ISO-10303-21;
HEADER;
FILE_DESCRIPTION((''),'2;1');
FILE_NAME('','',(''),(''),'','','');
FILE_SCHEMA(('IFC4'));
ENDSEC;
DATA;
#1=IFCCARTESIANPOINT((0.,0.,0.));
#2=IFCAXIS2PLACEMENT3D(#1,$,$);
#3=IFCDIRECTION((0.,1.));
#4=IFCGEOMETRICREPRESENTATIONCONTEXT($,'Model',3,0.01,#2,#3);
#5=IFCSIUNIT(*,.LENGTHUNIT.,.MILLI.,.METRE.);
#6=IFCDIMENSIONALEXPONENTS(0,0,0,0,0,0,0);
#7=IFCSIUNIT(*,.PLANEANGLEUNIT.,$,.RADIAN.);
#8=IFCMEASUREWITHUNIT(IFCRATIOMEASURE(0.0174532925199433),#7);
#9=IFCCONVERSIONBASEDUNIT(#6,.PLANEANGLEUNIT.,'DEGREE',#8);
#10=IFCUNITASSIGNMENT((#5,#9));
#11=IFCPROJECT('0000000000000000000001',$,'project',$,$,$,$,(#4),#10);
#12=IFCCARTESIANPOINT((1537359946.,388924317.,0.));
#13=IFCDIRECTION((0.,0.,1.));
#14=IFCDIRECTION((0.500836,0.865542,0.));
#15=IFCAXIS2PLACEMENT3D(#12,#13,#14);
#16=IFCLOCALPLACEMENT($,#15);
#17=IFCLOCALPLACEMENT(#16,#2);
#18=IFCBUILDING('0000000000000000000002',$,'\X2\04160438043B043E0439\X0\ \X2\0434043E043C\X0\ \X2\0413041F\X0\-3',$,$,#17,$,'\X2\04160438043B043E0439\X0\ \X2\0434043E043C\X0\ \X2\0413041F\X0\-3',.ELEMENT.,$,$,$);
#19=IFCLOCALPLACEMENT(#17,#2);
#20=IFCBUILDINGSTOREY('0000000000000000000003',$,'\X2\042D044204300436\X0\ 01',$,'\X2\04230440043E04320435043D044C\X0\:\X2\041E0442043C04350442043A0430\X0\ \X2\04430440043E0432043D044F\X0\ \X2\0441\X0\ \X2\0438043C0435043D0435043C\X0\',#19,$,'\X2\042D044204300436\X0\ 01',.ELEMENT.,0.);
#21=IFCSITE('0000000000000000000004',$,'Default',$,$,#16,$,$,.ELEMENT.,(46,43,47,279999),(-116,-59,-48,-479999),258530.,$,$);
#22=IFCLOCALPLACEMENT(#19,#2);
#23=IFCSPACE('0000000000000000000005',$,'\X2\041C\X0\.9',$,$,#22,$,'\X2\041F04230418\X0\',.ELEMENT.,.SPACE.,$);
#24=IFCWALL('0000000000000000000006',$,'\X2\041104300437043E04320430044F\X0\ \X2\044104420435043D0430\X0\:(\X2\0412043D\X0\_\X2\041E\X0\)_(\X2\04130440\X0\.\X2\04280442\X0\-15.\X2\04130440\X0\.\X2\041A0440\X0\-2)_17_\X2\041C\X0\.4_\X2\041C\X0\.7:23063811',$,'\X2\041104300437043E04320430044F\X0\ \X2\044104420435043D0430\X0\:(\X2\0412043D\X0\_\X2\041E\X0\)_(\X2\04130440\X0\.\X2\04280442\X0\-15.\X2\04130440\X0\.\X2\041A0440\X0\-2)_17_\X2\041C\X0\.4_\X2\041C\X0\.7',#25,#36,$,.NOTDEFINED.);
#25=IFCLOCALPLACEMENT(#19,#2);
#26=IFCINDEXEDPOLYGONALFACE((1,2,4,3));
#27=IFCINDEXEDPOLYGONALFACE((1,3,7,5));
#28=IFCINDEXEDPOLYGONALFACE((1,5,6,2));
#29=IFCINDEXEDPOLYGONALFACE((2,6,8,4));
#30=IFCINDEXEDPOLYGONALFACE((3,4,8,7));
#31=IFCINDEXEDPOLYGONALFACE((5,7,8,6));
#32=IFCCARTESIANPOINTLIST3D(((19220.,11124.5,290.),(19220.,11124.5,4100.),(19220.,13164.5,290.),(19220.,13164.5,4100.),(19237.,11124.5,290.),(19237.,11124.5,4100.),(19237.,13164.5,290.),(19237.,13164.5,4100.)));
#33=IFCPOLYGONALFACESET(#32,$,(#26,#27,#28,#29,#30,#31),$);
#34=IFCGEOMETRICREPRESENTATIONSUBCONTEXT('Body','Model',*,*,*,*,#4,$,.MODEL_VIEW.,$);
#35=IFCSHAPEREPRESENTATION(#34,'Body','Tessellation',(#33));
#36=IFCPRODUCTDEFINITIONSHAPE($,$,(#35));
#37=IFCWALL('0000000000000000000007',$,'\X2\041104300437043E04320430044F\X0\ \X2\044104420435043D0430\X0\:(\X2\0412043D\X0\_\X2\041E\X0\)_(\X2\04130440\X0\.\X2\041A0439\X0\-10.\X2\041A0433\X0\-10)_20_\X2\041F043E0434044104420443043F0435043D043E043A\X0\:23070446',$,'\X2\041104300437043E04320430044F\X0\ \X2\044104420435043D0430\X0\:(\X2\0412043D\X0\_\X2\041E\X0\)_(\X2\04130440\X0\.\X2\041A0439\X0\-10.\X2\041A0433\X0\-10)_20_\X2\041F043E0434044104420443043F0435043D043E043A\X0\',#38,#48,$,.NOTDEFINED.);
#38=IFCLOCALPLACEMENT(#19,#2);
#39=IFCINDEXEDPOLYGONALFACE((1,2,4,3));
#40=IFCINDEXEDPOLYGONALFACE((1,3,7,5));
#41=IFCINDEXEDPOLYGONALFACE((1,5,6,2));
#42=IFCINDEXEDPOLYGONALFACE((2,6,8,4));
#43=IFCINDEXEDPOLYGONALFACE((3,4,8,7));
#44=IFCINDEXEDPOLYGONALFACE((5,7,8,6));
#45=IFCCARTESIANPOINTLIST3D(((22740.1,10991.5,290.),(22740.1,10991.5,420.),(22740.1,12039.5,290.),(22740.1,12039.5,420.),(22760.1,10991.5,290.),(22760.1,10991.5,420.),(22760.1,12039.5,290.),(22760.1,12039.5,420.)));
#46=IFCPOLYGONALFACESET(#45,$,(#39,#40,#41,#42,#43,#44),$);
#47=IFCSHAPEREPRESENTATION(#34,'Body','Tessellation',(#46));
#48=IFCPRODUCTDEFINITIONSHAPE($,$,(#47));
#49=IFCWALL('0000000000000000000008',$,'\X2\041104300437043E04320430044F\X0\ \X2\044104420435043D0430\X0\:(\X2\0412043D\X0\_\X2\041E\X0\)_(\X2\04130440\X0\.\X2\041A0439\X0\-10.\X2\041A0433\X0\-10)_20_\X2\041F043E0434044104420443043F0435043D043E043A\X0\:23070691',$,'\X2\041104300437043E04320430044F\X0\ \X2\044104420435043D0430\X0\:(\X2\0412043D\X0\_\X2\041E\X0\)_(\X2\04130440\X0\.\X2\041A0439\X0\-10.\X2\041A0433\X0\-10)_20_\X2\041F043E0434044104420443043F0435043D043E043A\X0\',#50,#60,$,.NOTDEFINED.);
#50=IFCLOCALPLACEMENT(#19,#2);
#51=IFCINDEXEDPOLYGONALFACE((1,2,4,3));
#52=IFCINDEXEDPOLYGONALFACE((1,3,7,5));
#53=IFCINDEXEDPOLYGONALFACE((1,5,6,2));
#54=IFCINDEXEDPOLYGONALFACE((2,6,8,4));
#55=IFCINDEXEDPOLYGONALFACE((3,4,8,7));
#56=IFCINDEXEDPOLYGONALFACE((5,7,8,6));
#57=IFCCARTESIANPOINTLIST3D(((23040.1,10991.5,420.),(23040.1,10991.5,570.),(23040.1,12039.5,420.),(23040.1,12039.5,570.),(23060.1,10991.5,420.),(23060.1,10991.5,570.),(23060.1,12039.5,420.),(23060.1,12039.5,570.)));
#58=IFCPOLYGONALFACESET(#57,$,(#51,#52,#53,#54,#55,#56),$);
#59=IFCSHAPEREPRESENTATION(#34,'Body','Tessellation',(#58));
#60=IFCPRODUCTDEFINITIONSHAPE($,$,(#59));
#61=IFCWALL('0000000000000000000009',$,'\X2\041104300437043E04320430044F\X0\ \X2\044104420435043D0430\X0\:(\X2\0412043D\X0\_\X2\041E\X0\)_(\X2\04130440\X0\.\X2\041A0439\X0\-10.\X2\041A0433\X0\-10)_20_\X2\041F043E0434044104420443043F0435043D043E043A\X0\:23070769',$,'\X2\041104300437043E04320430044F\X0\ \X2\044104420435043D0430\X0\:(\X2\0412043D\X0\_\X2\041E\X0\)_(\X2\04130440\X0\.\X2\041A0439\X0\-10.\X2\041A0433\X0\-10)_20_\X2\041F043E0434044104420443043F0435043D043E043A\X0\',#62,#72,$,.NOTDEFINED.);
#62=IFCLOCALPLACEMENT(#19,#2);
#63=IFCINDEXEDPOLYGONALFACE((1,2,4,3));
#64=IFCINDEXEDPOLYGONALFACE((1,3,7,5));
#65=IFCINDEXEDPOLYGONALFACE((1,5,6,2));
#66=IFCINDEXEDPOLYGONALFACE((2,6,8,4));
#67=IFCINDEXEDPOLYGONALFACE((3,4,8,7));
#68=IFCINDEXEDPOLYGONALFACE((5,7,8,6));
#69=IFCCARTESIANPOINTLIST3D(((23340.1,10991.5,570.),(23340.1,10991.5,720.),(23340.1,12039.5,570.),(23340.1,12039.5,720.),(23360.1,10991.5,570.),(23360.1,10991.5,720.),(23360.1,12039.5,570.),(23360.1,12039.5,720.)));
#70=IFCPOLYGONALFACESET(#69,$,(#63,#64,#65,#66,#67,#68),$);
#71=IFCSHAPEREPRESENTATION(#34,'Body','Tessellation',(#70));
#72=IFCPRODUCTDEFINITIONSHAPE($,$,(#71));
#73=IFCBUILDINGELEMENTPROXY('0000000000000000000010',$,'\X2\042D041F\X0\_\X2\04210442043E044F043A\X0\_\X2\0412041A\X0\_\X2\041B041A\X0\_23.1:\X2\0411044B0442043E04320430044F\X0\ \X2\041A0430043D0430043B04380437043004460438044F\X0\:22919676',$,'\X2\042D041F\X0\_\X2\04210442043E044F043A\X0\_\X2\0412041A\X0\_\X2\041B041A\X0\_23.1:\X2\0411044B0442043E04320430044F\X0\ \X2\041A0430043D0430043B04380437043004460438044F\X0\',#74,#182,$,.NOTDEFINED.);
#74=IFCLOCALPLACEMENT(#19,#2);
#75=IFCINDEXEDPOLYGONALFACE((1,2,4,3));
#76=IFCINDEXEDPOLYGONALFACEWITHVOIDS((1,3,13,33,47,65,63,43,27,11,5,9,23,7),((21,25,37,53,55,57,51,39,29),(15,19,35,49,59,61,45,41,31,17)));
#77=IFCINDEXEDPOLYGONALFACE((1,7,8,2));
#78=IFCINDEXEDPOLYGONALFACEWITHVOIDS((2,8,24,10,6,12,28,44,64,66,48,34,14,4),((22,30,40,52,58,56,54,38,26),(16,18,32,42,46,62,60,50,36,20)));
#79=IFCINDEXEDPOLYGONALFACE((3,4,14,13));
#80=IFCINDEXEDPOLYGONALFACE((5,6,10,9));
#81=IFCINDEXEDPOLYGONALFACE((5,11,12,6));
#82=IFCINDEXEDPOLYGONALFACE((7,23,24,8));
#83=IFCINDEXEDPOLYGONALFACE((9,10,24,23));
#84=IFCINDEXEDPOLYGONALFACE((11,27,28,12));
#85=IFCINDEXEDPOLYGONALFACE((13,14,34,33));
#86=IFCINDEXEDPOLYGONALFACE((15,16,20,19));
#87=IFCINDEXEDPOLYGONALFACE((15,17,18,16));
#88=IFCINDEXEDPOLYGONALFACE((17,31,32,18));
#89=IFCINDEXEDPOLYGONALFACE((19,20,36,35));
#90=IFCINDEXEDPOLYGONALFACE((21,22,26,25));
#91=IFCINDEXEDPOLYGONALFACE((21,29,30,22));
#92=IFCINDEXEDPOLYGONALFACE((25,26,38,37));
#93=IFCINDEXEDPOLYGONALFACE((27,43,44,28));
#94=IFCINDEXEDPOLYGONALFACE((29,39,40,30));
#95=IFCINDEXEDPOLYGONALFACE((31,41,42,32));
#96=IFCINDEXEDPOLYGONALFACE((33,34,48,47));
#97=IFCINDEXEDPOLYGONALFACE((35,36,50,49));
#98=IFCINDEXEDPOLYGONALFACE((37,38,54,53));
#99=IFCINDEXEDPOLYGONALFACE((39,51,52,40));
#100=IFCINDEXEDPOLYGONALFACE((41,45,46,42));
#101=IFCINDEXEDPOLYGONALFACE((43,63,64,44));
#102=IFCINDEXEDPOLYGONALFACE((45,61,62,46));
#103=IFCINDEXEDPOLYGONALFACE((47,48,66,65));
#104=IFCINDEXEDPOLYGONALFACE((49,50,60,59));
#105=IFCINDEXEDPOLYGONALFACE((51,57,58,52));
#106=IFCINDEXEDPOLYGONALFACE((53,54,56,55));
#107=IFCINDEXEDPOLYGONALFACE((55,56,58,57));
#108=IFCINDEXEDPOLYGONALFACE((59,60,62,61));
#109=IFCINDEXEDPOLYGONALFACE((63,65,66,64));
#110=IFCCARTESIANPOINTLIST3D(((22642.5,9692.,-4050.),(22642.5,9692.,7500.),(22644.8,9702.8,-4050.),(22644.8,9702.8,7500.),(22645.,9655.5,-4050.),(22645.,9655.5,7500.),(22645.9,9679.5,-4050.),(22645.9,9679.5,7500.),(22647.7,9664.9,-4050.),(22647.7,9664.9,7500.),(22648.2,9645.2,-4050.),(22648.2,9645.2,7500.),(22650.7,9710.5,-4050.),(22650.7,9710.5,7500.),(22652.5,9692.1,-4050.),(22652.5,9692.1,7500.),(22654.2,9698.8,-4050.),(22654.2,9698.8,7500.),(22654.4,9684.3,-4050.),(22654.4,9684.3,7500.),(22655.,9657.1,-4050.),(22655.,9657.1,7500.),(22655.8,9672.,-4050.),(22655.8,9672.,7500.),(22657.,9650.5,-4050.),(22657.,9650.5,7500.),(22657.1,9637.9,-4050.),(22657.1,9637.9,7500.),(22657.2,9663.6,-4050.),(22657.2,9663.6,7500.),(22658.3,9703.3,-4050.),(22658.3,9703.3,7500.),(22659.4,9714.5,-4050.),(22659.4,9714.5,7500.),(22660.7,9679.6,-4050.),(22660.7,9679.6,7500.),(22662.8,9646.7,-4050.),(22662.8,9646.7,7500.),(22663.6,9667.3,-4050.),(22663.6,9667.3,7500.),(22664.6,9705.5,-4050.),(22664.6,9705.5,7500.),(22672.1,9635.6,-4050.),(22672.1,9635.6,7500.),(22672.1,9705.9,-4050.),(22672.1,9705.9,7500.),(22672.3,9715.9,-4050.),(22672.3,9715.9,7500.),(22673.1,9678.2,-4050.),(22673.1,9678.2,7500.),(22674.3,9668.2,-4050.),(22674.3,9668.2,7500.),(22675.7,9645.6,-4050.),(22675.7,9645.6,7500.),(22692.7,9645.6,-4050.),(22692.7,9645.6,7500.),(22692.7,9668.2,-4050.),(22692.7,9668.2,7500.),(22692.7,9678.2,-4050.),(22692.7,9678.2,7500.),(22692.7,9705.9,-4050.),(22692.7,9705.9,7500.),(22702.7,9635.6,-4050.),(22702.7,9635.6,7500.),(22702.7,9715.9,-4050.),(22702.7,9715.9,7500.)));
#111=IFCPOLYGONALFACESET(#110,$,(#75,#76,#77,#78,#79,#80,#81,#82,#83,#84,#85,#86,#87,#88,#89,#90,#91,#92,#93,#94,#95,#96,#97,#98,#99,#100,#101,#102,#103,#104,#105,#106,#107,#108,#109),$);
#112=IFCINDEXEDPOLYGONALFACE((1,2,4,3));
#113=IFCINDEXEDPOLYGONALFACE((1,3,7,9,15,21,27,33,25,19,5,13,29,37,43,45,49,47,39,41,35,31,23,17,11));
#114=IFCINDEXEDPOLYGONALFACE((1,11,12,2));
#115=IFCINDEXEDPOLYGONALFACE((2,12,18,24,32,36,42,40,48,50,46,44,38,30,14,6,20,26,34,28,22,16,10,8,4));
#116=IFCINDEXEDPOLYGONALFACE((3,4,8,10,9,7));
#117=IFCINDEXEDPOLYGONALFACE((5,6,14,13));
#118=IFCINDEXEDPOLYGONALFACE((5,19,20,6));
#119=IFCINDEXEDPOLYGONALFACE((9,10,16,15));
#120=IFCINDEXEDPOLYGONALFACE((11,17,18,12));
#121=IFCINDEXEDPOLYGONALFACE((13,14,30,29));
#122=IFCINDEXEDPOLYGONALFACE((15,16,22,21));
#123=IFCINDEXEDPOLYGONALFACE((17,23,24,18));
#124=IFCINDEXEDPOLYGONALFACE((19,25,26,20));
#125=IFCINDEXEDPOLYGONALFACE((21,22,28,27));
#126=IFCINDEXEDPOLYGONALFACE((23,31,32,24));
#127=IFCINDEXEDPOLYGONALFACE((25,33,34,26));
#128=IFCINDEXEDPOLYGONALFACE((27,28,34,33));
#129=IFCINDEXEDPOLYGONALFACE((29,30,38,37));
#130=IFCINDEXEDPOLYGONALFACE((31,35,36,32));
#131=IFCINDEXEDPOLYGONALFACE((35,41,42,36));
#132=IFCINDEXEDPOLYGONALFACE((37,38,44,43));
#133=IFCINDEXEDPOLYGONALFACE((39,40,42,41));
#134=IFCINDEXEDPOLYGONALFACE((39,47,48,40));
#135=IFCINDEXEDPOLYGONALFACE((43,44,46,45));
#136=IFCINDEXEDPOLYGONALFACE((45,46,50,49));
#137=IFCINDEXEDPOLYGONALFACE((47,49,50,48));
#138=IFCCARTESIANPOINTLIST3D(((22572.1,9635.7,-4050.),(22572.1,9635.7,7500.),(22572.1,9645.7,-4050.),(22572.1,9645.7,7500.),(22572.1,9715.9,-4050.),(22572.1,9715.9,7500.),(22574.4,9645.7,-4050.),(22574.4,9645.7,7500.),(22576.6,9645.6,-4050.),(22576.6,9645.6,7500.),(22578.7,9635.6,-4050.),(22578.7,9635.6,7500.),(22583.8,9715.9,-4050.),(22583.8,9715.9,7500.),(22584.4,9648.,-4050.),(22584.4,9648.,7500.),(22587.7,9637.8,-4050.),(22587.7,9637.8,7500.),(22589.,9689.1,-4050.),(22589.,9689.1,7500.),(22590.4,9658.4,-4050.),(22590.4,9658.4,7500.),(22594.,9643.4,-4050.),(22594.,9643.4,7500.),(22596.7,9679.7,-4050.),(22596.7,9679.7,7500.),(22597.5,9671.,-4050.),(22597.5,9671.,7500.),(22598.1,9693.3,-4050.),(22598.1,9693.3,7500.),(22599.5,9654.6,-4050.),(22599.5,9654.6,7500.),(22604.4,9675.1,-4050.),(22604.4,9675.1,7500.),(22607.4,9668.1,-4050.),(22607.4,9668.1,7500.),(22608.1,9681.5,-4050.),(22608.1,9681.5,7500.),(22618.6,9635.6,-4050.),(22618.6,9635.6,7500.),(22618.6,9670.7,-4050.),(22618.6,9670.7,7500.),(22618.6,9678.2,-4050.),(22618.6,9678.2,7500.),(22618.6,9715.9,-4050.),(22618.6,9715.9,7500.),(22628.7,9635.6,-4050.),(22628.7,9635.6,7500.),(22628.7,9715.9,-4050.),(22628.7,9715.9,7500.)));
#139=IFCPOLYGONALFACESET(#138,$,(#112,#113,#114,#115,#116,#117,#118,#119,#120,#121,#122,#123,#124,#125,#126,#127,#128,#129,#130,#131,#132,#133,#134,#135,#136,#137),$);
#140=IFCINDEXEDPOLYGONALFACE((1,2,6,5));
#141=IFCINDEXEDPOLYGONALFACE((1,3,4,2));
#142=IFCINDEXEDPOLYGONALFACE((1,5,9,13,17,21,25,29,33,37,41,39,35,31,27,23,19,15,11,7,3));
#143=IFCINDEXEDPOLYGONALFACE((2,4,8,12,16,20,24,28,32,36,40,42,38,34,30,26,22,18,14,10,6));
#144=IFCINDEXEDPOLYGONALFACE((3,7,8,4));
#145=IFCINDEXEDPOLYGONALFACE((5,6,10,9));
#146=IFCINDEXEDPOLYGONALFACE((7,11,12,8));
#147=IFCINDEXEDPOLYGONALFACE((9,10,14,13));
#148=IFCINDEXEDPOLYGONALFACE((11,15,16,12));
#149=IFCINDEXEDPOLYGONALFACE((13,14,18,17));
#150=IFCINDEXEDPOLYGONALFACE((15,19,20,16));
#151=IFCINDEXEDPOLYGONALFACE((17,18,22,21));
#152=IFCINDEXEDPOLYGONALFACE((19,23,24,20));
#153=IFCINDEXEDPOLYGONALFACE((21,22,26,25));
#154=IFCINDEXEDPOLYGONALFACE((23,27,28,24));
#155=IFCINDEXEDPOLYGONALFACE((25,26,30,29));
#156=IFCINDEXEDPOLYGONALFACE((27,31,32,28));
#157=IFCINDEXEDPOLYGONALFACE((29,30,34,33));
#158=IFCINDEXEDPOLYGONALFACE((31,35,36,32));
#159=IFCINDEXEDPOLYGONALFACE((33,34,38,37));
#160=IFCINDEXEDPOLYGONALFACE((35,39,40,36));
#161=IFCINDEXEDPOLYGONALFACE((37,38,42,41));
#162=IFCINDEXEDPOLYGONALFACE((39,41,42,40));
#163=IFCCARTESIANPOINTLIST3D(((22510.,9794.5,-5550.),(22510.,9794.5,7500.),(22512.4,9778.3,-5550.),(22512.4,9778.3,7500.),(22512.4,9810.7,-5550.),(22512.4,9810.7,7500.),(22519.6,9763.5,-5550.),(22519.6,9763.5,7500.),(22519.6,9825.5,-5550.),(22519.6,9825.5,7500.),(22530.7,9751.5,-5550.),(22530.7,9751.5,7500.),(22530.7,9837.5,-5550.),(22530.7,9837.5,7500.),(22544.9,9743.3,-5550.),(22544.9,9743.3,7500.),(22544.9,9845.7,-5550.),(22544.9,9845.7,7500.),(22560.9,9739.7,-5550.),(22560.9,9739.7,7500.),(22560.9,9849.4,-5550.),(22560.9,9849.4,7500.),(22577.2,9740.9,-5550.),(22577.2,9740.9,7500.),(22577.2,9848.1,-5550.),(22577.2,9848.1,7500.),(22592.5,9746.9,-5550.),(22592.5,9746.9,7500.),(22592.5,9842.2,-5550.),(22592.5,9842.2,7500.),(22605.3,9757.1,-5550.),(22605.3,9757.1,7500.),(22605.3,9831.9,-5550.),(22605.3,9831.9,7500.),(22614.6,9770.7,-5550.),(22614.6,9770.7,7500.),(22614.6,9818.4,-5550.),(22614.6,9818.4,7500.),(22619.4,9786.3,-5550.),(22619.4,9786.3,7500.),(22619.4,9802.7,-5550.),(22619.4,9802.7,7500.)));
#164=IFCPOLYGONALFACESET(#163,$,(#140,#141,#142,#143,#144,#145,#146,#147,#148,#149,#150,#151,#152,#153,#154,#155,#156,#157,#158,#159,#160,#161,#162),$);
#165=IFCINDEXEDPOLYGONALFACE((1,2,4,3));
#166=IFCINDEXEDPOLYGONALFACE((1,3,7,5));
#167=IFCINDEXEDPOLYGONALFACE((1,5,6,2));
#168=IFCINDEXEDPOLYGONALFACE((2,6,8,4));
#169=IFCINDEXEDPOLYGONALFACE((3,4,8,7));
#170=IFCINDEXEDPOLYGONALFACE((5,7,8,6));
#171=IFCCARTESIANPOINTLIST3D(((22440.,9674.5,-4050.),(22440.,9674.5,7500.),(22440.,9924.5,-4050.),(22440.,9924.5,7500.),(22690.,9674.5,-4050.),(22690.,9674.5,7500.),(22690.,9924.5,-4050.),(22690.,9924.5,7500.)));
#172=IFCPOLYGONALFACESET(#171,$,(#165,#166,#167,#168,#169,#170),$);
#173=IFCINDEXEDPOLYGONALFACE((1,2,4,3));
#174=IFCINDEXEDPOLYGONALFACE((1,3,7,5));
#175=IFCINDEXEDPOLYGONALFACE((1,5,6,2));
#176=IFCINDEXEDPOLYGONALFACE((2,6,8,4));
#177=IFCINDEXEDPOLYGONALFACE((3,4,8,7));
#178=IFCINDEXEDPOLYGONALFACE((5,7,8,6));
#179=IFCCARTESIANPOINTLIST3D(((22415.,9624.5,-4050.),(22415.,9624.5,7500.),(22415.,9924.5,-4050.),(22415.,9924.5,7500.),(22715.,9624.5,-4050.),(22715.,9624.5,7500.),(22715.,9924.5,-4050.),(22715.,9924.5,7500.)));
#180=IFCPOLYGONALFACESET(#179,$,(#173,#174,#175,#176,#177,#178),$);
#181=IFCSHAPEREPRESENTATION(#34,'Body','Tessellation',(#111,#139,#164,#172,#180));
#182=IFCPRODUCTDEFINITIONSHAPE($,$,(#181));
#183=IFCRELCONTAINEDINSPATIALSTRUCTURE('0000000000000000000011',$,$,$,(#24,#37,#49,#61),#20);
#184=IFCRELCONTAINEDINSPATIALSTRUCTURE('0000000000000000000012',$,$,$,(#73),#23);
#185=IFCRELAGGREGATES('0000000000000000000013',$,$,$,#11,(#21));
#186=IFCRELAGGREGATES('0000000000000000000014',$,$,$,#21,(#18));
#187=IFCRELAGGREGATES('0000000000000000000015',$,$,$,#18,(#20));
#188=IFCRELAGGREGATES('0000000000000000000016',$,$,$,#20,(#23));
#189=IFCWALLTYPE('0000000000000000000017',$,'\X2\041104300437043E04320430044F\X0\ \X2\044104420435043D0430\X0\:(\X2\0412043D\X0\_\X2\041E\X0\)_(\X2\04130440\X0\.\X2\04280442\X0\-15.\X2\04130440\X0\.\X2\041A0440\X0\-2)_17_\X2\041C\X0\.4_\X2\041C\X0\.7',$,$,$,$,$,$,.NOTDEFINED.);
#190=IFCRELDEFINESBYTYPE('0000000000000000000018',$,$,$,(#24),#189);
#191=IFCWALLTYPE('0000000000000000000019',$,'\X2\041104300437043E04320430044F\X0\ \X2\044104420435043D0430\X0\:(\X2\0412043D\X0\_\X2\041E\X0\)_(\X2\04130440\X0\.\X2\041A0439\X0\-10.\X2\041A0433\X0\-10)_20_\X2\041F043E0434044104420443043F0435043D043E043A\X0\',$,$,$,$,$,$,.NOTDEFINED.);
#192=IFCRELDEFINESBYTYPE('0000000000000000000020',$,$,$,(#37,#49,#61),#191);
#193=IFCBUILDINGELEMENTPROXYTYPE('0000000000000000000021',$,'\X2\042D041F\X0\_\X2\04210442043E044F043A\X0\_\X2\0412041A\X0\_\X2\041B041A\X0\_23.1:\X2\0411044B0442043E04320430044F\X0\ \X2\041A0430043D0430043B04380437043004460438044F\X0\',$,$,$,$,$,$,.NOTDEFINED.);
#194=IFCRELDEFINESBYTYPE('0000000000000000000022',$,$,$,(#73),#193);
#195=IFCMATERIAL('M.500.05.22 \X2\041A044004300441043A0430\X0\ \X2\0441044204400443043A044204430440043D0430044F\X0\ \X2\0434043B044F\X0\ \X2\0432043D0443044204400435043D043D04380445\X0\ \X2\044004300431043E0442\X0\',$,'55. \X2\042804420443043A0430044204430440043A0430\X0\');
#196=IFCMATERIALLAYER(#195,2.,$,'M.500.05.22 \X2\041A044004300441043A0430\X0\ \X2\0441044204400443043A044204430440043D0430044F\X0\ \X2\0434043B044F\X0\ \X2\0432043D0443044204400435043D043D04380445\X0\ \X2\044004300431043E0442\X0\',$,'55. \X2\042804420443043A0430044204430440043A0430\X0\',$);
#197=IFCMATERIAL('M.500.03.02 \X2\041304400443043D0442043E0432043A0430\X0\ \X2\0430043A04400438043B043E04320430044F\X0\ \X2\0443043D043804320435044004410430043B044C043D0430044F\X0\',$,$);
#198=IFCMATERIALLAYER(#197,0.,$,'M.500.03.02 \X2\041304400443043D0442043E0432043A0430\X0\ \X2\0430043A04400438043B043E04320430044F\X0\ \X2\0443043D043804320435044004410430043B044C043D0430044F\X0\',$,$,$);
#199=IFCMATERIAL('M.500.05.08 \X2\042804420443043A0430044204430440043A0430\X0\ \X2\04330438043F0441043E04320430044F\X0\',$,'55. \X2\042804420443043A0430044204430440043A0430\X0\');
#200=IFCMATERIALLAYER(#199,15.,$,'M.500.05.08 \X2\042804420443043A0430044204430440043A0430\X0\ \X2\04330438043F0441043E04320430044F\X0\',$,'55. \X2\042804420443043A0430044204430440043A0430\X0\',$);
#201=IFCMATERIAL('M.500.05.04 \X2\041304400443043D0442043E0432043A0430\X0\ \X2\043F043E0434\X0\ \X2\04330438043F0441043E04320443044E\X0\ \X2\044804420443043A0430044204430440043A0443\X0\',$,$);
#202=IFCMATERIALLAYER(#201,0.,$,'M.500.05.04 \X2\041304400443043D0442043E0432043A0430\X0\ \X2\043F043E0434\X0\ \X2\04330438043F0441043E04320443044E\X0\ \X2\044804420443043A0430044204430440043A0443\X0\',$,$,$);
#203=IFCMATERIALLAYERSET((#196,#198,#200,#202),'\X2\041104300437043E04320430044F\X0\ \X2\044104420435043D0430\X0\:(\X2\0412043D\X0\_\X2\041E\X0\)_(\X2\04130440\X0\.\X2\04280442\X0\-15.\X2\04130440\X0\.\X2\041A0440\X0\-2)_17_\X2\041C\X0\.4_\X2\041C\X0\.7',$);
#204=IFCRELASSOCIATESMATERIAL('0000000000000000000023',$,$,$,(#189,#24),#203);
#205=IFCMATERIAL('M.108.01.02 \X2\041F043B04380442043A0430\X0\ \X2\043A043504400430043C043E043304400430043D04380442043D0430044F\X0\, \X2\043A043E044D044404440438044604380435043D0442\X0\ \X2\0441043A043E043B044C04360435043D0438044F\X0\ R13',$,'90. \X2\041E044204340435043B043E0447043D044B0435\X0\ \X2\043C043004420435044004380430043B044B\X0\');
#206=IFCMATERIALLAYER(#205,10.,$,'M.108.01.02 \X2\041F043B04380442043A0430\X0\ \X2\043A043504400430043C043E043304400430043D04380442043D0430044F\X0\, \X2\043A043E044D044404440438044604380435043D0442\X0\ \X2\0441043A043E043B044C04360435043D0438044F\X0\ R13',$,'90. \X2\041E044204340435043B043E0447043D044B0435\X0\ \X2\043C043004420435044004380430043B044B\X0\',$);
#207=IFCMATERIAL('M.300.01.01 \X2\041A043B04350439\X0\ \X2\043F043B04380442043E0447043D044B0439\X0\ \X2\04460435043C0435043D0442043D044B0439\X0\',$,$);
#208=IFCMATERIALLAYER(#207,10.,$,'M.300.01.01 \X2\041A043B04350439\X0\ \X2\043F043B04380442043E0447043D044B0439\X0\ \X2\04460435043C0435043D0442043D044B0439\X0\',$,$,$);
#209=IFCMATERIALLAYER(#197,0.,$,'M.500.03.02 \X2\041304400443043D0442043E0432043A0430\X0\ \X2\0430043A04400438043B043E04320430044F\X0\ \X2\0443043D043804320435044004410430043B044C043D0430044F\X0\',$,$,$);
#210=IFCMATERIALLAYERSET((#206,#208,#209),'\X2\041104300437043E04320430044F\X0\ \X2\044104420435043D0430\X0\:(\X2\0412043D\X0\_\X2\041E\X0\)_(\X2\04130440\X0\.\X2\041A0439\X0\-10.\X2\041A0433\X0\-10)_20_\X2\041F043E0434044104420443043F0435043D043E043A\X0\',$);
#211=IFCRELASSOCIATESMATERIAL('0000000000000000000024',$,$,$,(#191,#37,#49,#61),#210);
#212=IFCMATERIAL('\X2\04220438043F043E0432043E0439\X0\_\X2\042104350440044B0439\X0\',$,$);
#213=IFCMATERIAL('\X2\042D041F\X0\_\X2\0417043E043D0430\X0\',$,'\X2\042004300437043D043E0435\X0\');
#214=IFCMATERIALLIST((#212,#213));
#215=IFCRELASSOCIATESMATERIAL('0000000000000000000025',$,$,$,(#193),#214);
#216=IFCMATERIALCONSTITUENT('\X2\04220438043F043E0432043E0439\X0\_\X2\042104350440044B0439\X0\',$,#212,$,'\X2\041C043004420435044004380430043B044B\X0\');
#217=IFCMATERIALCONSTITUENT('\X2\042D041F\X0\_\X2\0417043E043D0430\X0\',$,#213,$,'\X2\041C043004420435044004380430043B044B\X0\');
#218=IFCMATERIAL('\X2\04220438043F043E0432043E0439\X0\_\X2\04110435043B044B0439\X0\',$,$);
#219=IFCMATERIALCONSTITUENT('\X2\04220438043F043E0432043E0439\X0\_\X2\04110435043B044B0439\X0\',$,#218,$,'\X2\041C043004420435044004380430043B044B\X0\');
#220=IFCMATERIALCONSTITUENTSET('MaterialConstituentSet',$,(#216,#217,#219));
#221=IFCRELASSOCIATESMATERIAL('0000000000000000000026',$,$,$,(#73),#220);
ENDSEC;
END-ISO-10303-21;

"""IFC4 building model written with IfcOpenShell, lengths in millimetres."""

from ifc_helpers import new_model, entity, si_unit, converted_unit, direction, frame, frame_2d, origin, place, context, subcontext, project, spatial, polyline, rectangle, circle, outline, extrude, source, transform, mapped, material, material_list, layer, layer_set, layer_usage, constituent, constituent_set, type_object, type_shapes, element, save


model = new_model("IFC4")

# Units and contexts
model_context = context("Model", 3, precision=0.01, world=origin(), true_north=direction((0.0, 1.0)))
body_context = subcontext(model_context, "Body", "Model", "MODEL_VIEW")
ifc_project = project(units=[si_unit("LENGTHUNIT", "METRE", prefix="MILLI"), converted_unit("PLANEANGLEUNIT", "DEGREE", entity("IfcRatioMeasure", 0.0174532925199433), si_unit("PLANEANGLEUNIT", "RADIAN"), dimensions=[0, 0, 0, 0, 0, 0, 0])], contexts=[model_context])

# Site, building, storey
site_placement = place(None, frame((1537359946.0, 388924317.0, 0.0), z_axis=(0.0, 0.0, 1.0), x_axis=(0.500836, 0.865542, 0.0)))
site = spatial("IfcSite", under=ifc_project, at=site_placement, Name="Default", CompositionType="ELEMENT", RefLatitude=(46, 43, 47, 279999), RefLongitude=(-116, -59, -48, -479999), RefElevation=258530.0)
building_placement = place(site_placement, origin())
building = spatial("IfcBuilding", under=site, at=building_placement, Name="Жилой дом ГП-3", LongName="Жилой дом ГП-3", CompositionType="ELEMENT")
storey_placement = place(building_placement, origin())
storey = spatial("IfcBuildingStorey", under=building, at=storey_placement, Name="Этаж 01", ObjectType="Уровень:Отметка уровня с именем", LongName="Этаж 01", CompositionType="ELEMENT", Elevation=0.0)

# Shared definitions
ifc_material_1 = material(Name="M.500.03.02 Грунтовка акриловая универсальная")
ifc_material_2 = material(Name="M.500.05.22 Краска структурная для внутренних работ", Category="55. Штукатурка")

# Walls
ifc_material_3 = material(Name="M.500.05.08 Штукатурка гипсовая", Category="55. Штукатурка")
ifc_layer_1 = layer(ifc_material_2, 2.0, Name="M.500.05.22 Краска структурная для внутренних работ", Category="55. Штукатурка")
ifc_layer_2 = layer(ifc_material_1, 0.0, Name="M.500.03.02 Грунтовка акриловая универсальная")
ifc_layer_3 = layer(ifc_material_3, 15.0, Name="M.500.05.08 Штукатурка гипсовая", Category="55. Штукатурка")
ifc_material_4 = material(Name="M.500.05.04 Грунтовка под гипсовую штукатурку")
ifc_layer_4 = layer(ifc_material_4, 0.0, Name="M.500.05.04 Грунтовка под гипсовую штукатурку")
ifc_layer_set_1 = layer_set([ifc_layer_1, ifc_layer_2, ifc_layer_3, ifc_layer_4], Name="Базовая стена:(Вн_О)_(Гр.Шт-15.Гр.Кр-2)_17_М.4_М.7")
wall_type_1 = type_object("IfcWallType", Name="Базовая стена:(Вн_О)_(Гр.Шт-15.Гр.Кр-2)_17_М.4_М.7", PredefinedType="NOTDEFINED", material=ifc_layer_set_1)
ifc_layer_usage_1 = layer_usage(ifc_layer_set_1, "AXIS2", "NEGATIVE", 8.5)
wall_1_placement = place(storey_placement, frame((19228.5, 13164.5, 290.0), z_axis=(0.0, 0.0, 1.0), x_axis=(0.0, -1.0, 0.0)))
element("IfcWall", 1, at=wall_1_placement, inside=storey, type_object=wall_type_1, material=ifc_layer_usage_1, Name="Базовая стена:(Вн_О)_(Гр.Шт-15.Гр.Кр-2)_17_М.4_М.7:23063811", ObjectType="Базовая стена:(Вн_О)_(Гр.Шт-15.Гр.Кр-2)_17_М.4_М.7", PredefinedType="NOTDEFINED", context=body_context, shape_type="SweptSolid", body=[
    extrude(rectangle(XDim=2040.0, YDim=17.0, at=frame_2d((1020.0, 0.0), x_axis=(-1.0, 0.0))), origin(), (0.0, 0.0, 1.0), 3810.0),
])
ifc_material_5 = material(Name="M.108.01.02 Плитка керамогранитная, коэффициент скольжения R13", Category="90. Отделочные материалы")
ifc_layer_5 = layer(ifc_material_5, 10.0, Name="M.108.01.02 Плитка керамогранитная, коэффициент скольжения R13", Category="90. Отделочные материалы")
ifc_material_6 = material(Name="M.300.01.01 Клей плиточный цементный")
ifc_layer_6 = layer(ifc_material_6, 10.0, Name="M.300.01.01 Клей плиточный цементный")
ifc_layer_7 = layer(ifc_material_1, 0.0, Name="M.500.03.02 Грунтовка акриловая универсальная")
ifc_layer_set_2 = layer_set([ifc_layer_5, ifc_layer_6, ifc_layer_7], Name="Базовая стена:(Вн_О)_(Гр.Кй-10.Кг-10)_20_Подступенок")
ifc_layer_usage_2 = layer_usage(ifc_layer_set_2, "AXIS2", "NEGATIVE", 10.0)
wall_type_2 = type_object("IfcWallType", Name="Базовая стена:(Вн_О)_(Гр.Кй-10.Кг-10)_20_Подступенок", PredefinedType="NOTDEFINED", material=ifc_layer_set_2)
wall_2_placement = place(storey_placement, frame((22750.1, 10991.5, 290.0), z_axis=(0.0, 0.0, 1.0), x_axis=(0.0, 1.0, 0.0)))
element("IfcWall", 2, at=wall_2_placement, inside=storey, type_object=wall_type_2, material=ifc_layer_usage_2, Name="Базовая стена:(Вн_О)_(Гр.Кй-10.Кг-10)_20_Подступенок:23070446", ObjectType="Базовая стена:(Вн_О)_(Гр.Кй-10.Кг-10)_20_Подступенок", PredefinedType="NOTDEFINED", context=body_context, shape_type="SweptSolid", body=[
    extrude(rectangle(XDim=1048.0, YDim=20.0, at=frame_2d((524.0, 0.0), x_axis=(-1.0, 0.0))), origin(), (0.0, 0.0, 1.0), 130.0),
])
ifc_layer_usage_3 = layer_usage(ifc_layer_set_2, "AXIS2", "NEGATIVE", 10.0)
wall_3_placement = place(storey_placement, frame((23050.1, 10991.5, 420.0), z_axis=(0.0, 0.0, 1.0), x_axis=(0.0, 1.0, 0.0)))
element("IfcWall", 3, at=wall_3_placement, inside=storey, type_object=wall_type_2, material=ifc_layer_usage_3, Name="Базовая стена:(Вн_О)_(Гр.Кй-10.Кг-10)_20_Подступенок:23070691", ObjectType="Базовая стена:(Вн_О)_(Гр.Кй-10.Кг-10)_20_Подступенок", PredefinedType="NOTDEFINED", context=body_context, shape_type="SweptSolid", body=[
    extrude(rectangle(XDim=1048.0, YDim=20.0, at=frame_2d((524.0, 0.0), x_axis=(-1.0, 0.0))), origin(), (0.0, 0.0, 1.0), 150.0),
])
ifc_layer_usage_4 = layer_usage(ifc_layer_set_2, "AXIS2", "NEGATIVE", 10.0)
wall_4_placement = place(storey_placement, frame((23350.1, 10991.5, 570.0), z_axis=(0.0, 0.0, 1.0), x_axis=(0.0, 1.0, 0.0)))
element("IfcWall", 4, at=wall_4_placement, inside=storey, type_object=wall_type_2, material=ifc_layer_usage_4, Name="Базовая стена:(Вн_О)_(Гр.Кй-10.Кг-10)_20_Подступенок:23070769", ObjectType="Базовая стена:(Вн_О)_(Гр.Кй-10.Кг-10)_20_Подступенок", PredefinedType="NOTDEFINED", context=body_context, shape_type="SweptSolid", body=[
    extrude(rectangle(XDim=1048.0, YDim=20.0, at=frame_2d((524.0, 0.0), x_axis=(-1.0, 0.0))), origin(), (0.0, 0.0, 1.0), 150.0),
])

# Shared definitions
ifc_material_7 = material(Name="Типовой_Серый")
ifc_material_8 = material(Name="ЭП_Зона", Category="Разное")

# Shared definitions
space_1_placement = place(storey_placement, origin())
space_1 = spatial("IfcSpace", under=storey, at=space_1_placement, Name="М.9", LongName="ПУИ", CompositionType="ELEMENT", PredefinedType="SPACE")

# Building element proxy
ifc_constituent_1 = constituent(ifc_material_7, Name="Типовой_Серый", Category="Материалы")
ifc_constituent_2 = constituent(ifc_material_8, Name="ЭП_Зона", Category="Материалы")
ifc_material_9 = material(Name="Типовой_Белый")
ifc_constituent_3 = constituent(ifc_material_9, Name="Типовой_Белый", Category="Материалы")
ifc_constituent_set_1 = constituent_set(constituents=[ifc_constituent_1, ifc_constituent_2, ifc_constituent_3], Name="MaterialConstituentSet")
ifc_material_list_1 = material_list([ifc_material_7, ifc_material_8])
building_element_proxy_type_1 = type_object("IfcBuildingElementProxyType", Name="ЭП_Стояк_ВК_ЛК_23.1:Бытовая Канализация", PredefinedType="NOTDEFINED", material=ifc_material_list_1)
shared_shape_1 = source(origin(), body_context, "Body", "SweptSolid", [
    extrude(outline(polyline([(-42.2, -39.0), (-11.8, -39.0), (1.1, -37.6), (9.8, -33.5), (15.7, -25.8), (18.0, -15.0), (14.6, -2.5), (4.7, 5.0), (12.8, 12.1), (15.5, 21.5), (12.3, 31.8), (3.4, 39.0), (-11.6, 41.4), (-42.2, 41.4), (-42.2, -39.0)]), holes=[polyline([(-32.2, 8.8), (-32.2, 31.4), (-15.2, 31.4), (-2.3, 30.3), (3.5, 26.4), (5.5, 19.9), (3.3, 13.3), (-3.1, 9.6), (-13.9, 8.8), (-32.2, 8.8)]), polyline([(-32.2, -28.9), (-32.2, -1.3), (-12.6, -1.3), (-0.2, -2.6), (6.1, -7.3), (8.0, -15.1), (6.3, -21.9), (2.2, -26.3), (-4.1, -28.5), (-11.6, -28.9), (-32.2, -28.9)])]), frame((54.5, -52.4, -4050.0)), (0.0, 0.0, 1.0), 11550.0),
    extrude(outline(polyline([(-32.1, -31.9), (48.3, -31.9), (48.3, -21.8), (10.6, -21.8), (13.8, -11.4), (25.6, -1.3), (48.3, 13.0), (48.3, 24.6), (21.4, 7.7), (12.0, 0.1), (7.4, -7.7), (3.3, -0.7), (-9.3, 6.4), (-19.7, 12.3), (-22.1, 20.2), (-22.0, 22.4), (-22.0, 24.6), (-32.0, 24.6), (-32.1, 18.0), (-29.9, 9.0), (-24.3, 2.8), (-13.1, -2.8), (0.4, -10.6), (3.0, -21.8), (-32.1, -21.8), (-32.1, -31.9)])), frame((118.2, -43.1, -4050.0), z_axis=(0.0, 0.0, 1.0), x_axis=(0.0, -1.0, 0.0)), (0.0, 0.0, 1.0), 11550.0),
    extrude(circle(Radius=55.0, at=frame_2d((0.0, 0.0), x_axis=(1.0, 0.0))), frame((150.0, -170.0, -5550.0)), (0.0, 0.0, 1.0), 13050.0),
    extrude(rectangle(XDim=250.0, YDim=250.0, at=frame_2d((0.0, 0.0), x_axis=(1.0, 0.0))), frame((150.0, -175.0, -4050.0)), (0.0, 0.0, 1.0), 11550.0),
    extrude(rectangle(XDim=300.0, YDim=300.0, at=frame_2d((0.0, 0.0), x_axis=(1.0, 0.0))), frame((150.0, -150.0, -4050.0)), (0.0, 0.0, 1.0), 11550.0),
])
type_shapes(building_element_proxy_type_1, [shared_shape_1])
proxy_1_placement = place(space_1_placement, frame((22715.0, 9624.5, 0.0), z_axis=(0.0, 0.0, 1.0), x_axis=(-1.0, 0.0, 0.0)))
element("IfcBuildingElementProxy", 5, at=proxy_1_placement, inside=space_1, type_object=building_element_proxy_type_1, material=ifc_constituent_set_1, Name="ЭП_Стояк_ВК_ЛК_23.1:Бытовая Канализация:22919676", ObjectType="ЭП_Стояк_ВК_ЛК_23.1:Бытовая Канализация", PredefinedType="NOTDEFINED", context=body_context, shape_type="MappedRepresentation", body=[
    mapped(shared_shape_1, transform((0.0, 0.0, 0.0), scale=1.0)),
])

save(model, "model.ifc")
